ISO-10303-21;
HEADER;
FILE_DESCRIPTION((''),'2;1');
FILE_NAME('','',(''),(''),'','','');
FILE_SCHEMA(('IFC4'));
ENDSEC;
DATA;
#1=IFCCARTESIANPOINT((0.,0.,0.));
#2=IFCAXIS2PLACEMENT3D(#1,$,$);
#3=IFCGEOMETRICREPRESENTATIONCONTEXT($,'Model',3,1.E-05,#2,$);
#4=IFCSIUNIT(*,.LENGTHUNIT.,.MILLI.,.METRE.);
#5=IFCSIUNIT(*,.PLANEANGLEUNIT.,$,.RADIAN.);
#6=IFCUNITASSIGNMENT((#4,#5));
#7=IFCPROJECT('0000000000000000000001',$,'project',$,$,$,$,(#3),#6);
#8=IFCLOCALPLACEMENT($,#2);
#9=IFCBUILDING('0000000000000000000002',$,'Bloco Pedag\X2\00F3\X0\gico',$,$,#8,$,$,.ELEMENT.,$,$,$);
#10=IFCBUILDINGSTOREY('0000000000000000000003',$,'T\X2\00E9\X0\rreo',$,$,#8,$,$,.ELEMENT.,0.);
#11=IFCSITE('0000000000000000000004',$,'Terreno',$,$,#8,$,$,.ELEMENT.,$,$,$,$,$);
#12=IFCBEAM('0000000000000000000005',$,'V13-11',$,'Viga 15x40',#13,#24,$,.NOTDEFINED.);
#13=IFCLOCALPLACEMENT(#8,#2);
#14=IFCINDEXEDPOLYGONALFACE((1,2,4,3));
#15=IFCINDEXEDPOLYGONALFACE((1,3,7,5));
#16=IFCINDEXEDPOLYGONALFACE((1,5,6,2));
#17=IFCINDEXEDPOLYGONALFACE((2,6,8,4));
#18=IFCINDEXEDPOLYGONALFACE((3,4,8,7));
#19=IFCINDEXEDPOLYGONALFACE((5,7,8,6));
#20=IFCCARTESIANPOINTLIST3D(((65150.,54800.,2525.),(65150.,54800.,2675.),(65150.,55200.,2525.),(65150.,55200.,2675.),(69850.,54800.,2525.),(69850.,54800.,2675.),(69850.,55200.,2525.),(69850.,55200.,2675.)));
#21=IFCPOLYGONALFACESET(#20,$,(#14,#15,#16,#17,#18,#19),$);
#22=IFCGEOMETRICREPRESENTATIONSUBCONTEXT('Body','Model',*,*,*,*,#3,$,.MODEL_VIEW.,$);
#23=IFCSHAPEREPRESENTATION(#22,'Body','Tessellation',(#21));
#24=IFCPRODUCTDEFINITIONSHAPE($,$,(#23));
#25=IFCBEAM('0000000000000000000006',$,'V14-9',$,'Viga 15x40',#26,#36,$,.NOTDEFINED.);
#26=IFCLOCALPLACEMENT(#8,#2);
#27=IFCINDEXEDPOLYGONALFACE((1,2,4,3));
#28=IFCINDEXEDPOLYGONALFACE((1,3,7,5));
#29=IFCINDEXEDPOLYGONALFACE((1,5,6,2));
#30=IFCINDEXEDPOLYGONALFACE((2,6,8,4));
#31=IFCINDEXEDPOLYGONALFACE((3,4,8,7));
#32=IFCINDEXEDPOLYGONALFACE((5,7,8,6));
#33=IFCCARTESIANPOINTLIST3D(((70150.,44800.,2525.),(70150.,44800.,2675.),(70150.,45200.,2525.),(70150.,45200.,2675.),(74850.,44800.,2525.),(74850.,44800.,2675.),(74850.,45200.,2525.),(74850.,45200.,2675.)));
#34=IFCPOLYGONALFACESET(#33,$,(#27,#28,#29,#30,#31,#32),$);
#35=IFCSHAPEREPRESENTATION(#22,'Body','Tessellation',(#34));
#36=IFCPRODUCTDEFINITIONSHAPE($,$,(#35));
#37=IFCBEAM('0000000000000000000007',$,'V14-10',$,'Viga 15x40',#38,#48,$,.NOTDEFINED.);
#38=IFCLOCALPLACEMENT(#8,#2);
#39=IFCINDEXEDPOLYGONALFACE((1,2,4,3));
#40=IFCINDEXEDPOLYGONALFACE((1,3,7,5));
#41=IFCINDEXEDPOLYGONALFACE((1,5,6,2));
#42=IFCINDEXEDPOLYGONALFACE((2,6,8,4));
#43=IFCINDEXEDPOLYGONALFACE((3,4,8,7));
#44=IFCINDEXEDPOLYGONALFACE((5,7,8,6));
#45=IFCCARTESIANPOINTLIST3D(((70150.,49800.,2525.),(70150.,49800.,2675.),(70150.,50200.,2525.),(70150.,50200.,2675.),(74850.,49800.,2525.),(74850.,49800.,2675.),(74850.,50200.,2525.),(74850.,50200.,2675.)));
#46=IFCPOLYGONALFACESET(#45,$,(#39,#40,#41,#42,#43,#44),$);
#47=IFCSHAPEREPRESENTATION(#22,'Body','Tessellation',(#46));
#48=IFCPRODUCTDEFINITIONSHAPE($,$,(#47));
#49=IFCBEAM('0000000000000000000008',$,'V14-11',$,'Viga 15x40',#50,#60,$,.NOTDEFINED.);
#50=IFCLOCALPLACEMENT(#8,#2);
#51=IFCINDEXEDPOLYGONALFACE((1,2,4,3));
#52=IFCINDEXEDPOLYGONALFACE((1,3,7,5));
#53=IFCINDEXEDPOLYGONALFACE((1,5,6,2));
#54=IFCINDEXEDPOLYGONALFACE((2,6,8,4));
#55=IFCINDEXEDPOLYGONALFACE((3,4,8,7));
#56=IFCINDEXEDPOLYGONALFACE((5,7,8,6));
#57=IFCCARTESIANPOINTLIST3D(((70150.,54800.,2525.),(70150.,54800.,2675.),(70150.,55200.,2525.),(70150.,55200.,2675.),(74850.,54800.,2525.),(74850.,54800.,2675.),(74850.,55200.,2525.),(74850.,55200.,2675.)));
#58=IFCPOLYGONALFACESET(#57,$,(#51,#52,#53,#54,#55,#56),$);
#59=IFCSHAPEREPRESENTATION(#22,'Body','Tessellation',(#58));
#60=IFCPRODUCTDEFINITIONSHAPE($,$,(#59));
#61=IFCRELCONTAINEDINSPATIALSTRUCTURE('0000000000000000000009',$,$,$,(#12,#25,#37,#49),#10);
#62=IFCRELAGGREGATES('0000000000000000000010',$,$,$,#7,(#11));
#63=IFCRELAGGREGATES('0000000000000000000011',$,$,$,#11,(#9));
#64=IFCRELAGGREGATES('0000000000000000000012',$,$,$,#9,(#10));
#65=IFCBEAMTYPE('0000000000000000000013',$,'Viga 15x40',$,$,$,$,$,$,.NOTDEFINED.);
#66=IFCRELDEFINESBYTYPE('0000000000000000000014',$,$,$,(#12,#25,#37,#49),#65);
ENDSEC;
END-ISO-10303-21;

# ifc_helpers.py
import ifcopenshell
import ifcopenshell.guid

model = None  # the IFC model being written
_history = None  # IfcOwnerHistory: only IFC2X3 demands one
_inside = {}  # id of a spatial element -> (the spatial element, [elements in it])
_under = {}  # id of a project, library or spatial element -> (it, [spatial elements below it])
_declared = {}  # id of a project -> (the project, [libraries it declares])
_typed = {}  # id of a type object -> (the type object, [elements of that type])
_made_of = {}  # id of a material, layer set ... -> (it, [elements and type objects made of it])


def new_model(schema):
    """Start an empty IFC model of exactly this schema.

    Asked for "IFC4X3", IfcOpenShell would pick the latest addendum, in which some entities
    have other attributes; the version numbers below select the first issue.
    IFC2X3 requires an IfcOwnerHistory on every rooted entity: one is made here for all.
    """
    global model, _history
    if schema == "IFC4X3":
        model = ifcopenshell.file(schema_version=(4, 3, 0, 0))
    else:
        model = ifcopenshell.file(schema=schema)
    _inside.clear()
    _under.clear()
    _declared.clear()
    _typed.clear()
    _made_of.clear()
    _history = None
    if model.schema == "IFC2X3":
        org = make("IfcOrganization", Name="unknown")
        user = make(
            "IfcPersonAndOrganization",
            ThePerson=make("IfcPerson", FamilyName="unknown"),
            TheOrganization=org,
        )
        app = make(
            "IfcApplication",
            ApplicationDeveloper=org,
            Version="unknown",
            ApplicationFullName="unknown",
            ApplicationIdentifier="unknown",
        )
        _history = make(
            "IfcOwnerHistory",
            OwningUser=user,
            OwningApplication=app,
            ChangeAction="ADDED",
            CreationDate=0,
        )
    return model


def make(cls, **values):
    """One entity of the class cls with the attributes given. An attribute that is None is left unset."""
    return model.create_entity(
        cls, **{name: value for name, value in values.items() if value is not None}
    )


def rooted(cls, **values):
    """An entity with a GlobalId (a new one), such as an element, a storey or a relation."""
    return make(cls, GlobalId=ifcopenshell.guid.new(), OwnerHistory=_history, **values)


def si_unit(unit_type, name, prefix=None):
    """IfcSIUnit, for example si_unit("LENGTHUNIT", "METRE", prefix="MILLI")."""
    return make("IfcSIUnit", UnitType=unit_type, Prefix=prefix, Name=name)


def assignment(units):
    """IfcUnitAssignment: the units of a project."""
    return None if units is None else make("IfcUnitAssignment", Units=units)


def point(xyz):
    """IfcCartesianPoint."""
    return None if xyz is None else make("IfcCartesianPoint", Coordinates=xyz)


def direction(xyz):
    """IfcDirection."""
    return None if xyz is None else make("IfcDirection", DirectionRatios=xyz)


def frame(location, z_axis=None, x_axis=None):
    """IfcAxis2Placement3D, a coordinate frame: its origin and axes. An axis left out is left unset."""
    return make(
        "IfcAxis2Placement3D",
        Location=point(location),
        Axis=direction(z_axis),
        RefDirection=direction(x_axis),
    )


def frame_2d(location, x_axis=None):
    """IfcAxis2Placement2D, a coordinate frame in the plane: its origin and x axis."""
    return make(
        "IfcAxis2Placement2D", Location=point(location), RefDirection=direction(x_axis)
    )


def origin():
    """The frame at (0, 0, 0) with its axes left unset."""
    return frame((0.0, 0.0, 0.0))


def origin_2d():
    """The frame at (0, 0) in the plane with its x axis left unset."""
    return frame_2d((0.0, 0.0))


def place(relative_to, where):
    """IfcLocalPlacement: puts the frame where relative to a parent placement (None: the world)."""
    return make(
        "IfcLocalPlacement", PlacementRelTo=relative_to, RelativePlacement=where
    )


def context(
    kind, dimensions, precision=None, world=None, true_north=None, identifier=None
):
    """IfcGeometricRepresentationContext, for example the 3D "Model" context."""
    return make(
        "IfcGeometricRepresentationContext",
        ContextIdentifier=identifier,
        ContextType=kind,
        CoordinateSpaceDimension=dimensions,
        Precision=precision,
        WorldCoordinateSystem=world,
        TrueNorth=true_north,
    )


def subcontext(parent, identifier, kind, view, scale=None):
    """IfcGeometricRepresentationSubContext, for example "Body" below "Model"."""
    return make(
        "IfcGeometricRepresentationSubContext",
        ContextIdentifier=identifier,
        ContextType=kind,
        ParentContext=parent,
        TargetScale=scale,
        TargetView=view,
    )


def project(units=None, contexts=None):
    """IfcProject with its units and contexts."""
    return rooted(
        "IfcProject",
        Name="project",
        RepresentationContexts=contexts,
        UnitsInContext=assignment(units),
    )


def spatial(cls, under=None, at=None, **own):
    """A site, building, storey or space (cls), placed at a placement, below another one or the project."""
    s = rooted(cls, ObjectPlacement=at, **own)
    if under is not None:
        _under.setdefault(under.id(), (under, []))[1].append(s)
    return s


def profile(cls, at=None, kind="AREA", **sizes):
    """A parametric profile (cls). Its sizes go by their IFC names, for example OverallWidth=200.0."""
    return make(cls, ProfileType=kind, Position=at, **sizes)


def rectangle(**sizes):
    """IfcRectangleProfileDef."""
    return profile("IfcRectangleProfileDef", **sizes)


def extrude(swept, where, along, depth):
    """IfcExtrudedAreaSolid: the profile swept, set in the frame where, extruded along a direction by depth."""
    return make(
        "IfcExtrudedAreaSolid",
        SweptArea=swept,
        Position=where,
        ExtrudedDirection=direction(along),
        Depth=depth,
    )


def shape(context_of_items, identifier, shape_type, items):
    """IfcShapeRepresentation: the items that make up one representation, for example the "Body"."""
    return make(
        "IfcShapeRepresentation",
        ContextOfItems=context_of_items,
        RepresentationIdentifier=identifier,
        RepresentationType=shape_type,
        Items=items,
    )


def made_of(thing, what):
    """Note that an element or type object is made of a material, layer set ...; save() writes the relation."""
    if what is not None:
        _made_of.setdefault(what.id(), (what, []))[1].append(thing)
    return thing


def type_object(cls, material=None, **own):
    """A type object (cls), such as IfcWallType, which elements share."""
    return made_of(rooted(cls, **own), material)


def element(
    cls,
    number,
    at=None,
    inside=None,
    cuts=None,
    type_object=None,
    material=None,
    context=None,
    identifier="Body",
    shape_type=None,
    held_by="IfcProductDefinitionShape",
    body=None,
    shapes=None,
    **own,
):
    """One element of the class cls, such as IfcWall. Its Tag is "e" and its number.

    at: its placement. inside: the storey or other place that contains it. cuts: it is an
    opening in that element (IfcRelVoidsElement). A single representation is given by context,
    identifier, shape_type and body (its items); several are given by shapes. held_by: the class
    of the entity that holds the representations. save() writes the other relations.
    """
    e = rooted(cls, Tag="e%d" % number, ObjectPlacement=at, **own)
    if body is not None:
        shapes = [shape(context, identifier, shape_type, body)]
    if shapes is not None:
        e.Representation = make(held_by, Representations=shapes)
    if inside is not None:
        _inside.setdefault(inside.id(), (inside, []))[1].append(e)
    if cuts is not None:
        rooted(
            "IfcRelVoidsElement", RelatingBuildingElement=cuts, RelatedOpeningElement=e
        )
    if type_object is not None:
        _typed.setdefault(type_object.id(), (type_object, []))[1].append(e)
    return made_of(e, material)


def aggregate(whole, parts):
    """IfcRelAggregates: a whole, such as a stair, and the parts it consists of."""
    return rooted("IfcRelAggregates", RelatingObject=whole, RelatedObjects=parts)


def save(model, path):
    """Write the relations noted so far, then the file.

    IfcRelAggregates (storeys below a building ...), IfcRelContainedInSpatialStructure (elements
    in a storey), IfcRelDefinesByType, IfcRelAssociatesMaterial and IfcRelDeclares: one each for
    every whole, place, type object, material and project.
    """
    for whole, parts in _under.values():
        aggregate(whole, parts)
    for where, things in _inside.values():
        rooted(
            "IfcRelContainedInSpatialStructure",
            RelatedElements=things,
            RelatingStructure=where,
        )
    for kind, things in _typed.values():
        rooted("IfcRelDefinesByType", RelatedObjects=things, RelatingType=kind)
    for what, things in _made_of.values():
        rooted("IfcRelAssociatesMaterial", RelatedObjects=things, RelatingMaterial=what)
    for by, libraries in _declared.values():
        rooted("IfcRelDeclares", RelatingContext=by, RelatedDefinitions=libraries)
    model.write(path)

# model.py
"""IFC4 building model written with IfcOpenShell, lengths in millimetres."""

from ifc_helpers import new_model, si_unit, frame, origin, origin_2d, place, context, subcontext, project, spatial, rectangle, extrude, type_object, element, save


model = new_model("IFC4")

# Units and contexts
model_context = context("Model", 3, precision=1e-05, world=origin())
body_context = subcontext(model_context, "Body", "Model", "MODEL_VIEW")
ifc_project = project(units=[si_unit("LENGTHUNIT", "METRE", prefix="MILLI"), si_unit("PLANEANGLEUNIT", "RADIAN")], contexts=[model_context])

# Site, building, storey
placement = place(None, origin())
site = spatial("IfcSite", under=ifc_project, at=placement, Name="Terreno", CompositionType="ELEMENT")
building = spatial("IfcBuilding", under=site, at=placement, Name="Bloco Pedagógico", CompositionType="ELEMENT")
storey = spatial("IfcBuildingStorey", under=building, at=placement, Name="Térreo", CompositionType="ELEMENT", Elevation=0.0)

# Beams
beam_type = type_object("IfcBeamType", Name="Viga 15x40", PredefinedType="NOTDEFINED")
for number, where, z_axis, x_axis, name in (
    (1, (65150.0, 55000.0, 2600.0), (1.0, 0.0, 0.0), (0.0, 1.0, 0.0), "V13-11"),
    (2, (70150.0, 45000.0, 2600.0), (1.0, 0.0, 0.0), (0.0, 1.0, 0.0), "V14-9"),
    (3, (70150.0, 50000.0, 2600.0), (1.0, 0.0, 0.0), (0.0, 1.0, 0.0), "V14-10"),
    (4, (70150.0, 55000.0, 2600.0), (1.0, 0.0, 0.0), (0.0, 1.0, 0.0), "V14-11"),
):
    element("IfcBeam", number, at=place(None, frame(where, z_axis=z_axis, x_axis=x_axis)), inside=storey, type_object=beam_type, Name=name, ObjectType="Viga 15x40", PredefinedType="NOTDEFINED", context=body_context, shape_type="SweptSolid", body=[
        extrude(rectangle(XDim=400.0, YDim=150.0, at=origin_2d()), None, (0.0, 0.0, 1.0), 4700.0),
    ])

save(model, "model.ifc")
